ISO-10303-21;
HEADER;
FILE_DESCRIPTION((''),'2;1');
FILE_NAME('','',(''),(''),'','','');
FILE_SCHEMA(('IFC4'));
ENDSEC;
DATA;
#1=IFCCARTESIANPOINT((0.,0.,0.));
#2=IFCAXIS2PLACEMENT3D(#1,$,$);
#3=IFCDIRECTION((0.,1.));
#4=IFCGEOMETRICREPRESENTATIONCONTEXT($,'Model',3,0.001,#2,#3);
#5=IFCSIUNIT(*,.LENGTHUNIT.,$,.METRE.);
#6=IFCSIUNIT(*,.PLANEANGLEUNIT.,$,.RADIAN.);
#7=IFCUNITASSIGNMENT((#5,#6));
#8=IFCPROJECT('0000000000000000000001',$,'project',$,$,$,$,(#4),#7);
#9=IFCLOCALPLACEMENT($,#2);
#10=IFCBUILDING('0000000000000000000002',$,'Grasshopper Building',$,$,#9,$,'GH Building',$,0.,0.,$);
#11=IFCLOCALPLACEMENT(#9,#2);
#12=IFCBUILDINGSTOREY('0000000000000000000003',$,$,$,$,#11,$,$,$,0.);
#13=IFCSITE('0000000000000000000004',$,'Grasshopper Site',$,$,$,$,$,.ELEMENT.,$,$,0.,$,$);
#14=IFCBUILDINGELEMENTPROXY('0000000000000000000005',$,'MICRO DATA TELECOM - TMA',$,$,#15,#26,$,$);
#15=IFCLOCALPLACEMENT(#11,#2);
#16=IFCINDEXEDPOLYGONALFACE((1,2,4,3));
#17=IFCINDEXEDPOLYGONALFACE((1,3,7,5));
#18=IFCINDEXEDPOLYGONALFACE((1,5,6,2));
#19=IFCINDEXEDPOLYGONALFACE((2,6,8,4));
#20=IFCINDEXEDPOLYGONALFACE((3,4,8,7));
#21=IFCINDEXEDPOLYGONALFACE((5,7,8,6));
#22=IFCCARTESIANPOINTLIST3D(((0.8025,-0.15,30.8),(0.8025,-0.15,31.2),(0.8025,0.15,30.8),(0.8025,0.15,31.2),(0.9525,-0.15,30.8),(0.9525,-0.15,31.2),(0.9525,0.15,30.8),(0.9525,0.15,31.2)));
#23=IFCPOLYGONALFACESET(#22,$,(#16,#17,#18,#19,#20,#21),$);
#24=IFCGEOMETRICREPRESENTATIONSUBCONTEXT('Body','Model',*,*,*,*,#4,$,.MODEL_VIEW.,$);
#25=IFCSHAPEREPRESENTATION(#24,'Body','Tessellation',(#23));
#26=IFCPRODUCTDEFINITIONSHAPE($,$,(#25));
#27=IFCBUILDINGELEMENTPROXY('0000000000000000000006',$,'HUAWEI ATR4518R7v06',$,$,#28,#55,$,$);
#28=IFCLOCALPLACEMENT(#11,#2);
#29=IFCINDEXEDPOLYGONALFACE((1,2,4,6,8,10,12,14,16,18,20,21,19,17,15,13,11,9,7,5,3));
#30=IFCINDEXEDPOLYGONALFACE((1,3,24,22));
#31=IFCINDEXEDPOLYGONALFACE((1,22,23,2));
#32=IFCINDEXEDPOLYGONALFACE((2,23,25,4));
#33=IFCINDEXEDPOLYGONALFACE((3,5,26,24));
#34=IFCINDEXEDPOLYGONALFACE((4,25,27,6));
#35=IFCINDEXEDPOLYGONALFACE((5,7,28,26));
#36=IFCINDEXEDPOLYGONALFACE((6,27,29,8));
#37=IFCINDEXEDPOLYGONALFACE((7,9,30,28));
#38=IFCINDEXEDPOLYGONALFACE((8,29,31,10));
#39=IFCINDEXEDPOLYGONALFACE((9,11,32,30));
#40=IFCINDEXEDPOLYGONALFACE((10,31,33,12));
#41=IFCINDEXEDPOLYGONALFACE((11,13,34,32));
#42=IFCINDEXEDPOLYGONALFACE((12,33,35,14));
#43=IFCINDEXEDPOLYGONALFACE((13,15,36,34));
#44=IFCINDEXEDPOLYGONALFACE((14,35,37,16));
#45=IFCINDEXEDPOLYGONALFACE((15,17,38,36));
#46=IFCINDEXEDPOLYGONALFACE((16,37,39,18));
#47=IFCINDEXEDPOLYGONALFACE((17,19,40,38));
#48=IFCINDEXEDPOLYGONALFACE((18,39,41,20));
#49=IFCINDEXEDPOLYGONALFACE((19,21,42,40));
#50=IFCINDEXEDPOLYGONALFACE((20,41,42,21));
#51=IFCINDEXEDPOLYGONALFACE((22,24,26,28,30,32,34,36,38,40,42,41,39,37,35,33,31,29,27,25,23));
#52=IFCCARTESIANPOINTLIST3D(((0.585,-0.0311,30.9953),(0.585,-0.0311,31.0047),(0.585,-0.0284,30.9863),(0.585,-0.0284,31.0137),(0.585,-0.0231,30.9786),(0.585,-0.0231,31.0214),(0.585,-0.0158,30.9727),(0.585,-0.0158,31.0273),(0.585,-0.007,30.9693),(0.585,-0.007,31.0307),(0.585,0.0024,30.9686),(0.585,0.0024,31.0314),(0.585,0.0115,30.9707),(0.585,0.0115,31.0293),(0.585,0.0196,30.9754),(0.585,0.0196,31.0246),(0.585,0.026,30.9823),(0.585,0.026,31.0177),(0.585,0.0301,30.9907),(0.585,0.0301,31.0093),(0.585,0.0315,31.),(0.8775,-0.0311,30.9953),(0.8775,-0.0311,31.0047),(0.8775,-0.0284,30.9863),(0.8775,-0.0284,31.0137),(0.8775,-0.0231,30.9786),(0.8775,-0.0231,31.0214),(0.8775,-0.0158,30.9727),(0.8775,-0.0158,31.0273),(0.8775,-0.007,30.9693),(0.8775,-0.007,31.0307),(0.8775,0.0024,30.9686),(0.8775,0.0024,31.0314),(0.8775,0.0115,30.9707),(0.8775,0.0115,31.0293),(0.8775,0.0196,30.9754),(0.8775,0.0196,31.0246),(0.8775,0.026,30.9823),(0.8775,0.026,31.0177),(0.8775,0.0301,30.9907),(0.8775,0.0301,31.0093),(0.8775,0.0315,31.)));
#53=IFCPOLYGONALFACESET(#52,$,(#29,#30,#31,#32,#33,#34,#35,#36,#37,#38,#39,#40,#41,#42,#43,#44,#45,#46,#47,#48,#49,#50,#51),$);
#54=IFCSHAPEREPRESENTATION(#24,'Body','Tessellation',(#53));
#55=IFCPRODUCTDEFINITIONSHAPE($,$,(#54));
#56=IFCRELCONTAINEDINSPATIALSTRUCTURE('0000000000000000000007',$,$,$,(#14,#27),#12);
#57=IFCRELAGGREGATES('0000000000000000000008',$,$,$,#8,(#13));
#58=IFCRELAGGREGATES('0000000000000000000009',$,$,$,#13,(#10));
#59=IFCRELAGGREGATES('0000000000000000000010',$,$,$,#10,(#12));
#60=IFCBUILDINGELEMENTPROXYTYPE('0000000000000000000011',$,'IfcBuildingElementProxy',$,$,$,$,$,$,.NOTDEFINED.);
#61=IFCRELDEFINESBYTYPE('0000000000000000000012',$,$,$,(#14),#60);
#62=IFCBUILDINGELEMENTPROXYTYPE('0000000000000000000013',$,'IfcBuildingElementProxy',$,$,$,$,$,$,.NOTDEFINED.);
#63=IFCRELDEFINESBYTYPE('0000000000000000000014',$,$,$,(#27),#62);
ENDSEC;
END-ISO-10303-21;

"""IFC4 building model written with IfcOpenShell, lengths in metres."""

from ifc_helpers import new_model, si_unit, direction, frame, frame_2d, origin, place, context, subcontext, project, spatial, rectangle, circle, extrude, source, transform, mapped, type_object, type_shapes, element, save


model = new_model("IFC4")

# Units and contexts
model_context = context("Model", 3, precision=0.001, world=origin(), true_north=direction((0.0, 1.0)))
body_context = subcontext(model_context, "Body", "Model", "MODEL_VIEW")
ifc_project = project(units=[si_unit("LENGTHUNIT", "METRE"), si_unit("PLANEANGLEUNIT", "RADIAN")], contexts=[model_context])

# Site, building, storey
site = spatial("IfcSite", under=ifc_project, Name="Grasshopper Site", CompositionType="ELEMENT", RefElevation=0.0)
building_placement = place(None, origin())
building = spatial("IfcBuilding", under=site, at=building_placement, Name="Grasshopper Building", LongName="GH Building", ElevationOfRefHeight=0.0, ElevationOfTerrain=0.0)
storey_placement = place(building_placement, origin())
storey = spatial("IfcBuildingStorey", under=building, at=storey_placement, Elevation=0.0)

# Building element proxies
building_element_proxy_type_1 = type_object("IfcBuildingElementProxyType", Name="IfcBuildingElementProxy", PredefinedType="NOTDEFINED")
shared_shape_1 = source(origin(), body_context, "Body", "SweptSolid", [
    extrude(rectangle(XDim=0.4, YDim=0.3, at=frame_2d((0.0, 0.0), x_axis=(0.0, 1.0))), frame((0.9525, 0.0, 31.0), z_axis=(-1.0, 0.0, 0.0), x_axis=(0.0, 1.0, 0.0)), (0.0, 0.0, 1.0), 0.15),
])
type_shapes(building_element_proxy_type_1, [shared_shape_1])
for number, where, name in (
    (1, (0.0, 0.0, 0.0), "MICRO DATA TELECOM - TMA"),
):
    element("IfcBuildingElementProxy", number, at=place(storey_placement, frame(where)), inside=storey, type_object=building_element_proxy_type_1, Name=name, context=body_context, shape_type="MappedRepresentation", body=[
        mapped(shared_shape_1, transform((0.0, 0.0, 0.0), scale=1.0)),
    ])
building_element_proxy_type_2 = type_object("IfcBuildingElementProxyType", Name="IfcBuildingElementProxy", PredefinedType="NOTDEFINED")
shared_shape_2 = source(origin(), body_context, "Body", "SweptSolid", [
    extrude(circle(Radius=0.0315), frame((0.585, 0.0, 31.0), z_axis=(1.0, 0.0, 0.0), x_axis=(0.0, 1.0, 0.0)), (0.0, 0.0, 1.0), 0.2925),
])
type_shapes(building_element_proxy_type_2, [shared_shape_2])
for number, where, name in (
    (2, (0.0, 0.0, 0.0), "HUAWEI ATR4518R7v06"),
):
    element("IfcBuildingElementProxy", number, at=place(storey_placement, frame(where)), inside=storey, type_object=building_element_proxy_type_2, Name=name, context=body_context, shape_type="MappedRepresentation", body=[
        mapped(shared_shape_2, transform((0.0, 0.0, 0.0), scale=1.0)),
    ])

save(model, "model.ifc")
